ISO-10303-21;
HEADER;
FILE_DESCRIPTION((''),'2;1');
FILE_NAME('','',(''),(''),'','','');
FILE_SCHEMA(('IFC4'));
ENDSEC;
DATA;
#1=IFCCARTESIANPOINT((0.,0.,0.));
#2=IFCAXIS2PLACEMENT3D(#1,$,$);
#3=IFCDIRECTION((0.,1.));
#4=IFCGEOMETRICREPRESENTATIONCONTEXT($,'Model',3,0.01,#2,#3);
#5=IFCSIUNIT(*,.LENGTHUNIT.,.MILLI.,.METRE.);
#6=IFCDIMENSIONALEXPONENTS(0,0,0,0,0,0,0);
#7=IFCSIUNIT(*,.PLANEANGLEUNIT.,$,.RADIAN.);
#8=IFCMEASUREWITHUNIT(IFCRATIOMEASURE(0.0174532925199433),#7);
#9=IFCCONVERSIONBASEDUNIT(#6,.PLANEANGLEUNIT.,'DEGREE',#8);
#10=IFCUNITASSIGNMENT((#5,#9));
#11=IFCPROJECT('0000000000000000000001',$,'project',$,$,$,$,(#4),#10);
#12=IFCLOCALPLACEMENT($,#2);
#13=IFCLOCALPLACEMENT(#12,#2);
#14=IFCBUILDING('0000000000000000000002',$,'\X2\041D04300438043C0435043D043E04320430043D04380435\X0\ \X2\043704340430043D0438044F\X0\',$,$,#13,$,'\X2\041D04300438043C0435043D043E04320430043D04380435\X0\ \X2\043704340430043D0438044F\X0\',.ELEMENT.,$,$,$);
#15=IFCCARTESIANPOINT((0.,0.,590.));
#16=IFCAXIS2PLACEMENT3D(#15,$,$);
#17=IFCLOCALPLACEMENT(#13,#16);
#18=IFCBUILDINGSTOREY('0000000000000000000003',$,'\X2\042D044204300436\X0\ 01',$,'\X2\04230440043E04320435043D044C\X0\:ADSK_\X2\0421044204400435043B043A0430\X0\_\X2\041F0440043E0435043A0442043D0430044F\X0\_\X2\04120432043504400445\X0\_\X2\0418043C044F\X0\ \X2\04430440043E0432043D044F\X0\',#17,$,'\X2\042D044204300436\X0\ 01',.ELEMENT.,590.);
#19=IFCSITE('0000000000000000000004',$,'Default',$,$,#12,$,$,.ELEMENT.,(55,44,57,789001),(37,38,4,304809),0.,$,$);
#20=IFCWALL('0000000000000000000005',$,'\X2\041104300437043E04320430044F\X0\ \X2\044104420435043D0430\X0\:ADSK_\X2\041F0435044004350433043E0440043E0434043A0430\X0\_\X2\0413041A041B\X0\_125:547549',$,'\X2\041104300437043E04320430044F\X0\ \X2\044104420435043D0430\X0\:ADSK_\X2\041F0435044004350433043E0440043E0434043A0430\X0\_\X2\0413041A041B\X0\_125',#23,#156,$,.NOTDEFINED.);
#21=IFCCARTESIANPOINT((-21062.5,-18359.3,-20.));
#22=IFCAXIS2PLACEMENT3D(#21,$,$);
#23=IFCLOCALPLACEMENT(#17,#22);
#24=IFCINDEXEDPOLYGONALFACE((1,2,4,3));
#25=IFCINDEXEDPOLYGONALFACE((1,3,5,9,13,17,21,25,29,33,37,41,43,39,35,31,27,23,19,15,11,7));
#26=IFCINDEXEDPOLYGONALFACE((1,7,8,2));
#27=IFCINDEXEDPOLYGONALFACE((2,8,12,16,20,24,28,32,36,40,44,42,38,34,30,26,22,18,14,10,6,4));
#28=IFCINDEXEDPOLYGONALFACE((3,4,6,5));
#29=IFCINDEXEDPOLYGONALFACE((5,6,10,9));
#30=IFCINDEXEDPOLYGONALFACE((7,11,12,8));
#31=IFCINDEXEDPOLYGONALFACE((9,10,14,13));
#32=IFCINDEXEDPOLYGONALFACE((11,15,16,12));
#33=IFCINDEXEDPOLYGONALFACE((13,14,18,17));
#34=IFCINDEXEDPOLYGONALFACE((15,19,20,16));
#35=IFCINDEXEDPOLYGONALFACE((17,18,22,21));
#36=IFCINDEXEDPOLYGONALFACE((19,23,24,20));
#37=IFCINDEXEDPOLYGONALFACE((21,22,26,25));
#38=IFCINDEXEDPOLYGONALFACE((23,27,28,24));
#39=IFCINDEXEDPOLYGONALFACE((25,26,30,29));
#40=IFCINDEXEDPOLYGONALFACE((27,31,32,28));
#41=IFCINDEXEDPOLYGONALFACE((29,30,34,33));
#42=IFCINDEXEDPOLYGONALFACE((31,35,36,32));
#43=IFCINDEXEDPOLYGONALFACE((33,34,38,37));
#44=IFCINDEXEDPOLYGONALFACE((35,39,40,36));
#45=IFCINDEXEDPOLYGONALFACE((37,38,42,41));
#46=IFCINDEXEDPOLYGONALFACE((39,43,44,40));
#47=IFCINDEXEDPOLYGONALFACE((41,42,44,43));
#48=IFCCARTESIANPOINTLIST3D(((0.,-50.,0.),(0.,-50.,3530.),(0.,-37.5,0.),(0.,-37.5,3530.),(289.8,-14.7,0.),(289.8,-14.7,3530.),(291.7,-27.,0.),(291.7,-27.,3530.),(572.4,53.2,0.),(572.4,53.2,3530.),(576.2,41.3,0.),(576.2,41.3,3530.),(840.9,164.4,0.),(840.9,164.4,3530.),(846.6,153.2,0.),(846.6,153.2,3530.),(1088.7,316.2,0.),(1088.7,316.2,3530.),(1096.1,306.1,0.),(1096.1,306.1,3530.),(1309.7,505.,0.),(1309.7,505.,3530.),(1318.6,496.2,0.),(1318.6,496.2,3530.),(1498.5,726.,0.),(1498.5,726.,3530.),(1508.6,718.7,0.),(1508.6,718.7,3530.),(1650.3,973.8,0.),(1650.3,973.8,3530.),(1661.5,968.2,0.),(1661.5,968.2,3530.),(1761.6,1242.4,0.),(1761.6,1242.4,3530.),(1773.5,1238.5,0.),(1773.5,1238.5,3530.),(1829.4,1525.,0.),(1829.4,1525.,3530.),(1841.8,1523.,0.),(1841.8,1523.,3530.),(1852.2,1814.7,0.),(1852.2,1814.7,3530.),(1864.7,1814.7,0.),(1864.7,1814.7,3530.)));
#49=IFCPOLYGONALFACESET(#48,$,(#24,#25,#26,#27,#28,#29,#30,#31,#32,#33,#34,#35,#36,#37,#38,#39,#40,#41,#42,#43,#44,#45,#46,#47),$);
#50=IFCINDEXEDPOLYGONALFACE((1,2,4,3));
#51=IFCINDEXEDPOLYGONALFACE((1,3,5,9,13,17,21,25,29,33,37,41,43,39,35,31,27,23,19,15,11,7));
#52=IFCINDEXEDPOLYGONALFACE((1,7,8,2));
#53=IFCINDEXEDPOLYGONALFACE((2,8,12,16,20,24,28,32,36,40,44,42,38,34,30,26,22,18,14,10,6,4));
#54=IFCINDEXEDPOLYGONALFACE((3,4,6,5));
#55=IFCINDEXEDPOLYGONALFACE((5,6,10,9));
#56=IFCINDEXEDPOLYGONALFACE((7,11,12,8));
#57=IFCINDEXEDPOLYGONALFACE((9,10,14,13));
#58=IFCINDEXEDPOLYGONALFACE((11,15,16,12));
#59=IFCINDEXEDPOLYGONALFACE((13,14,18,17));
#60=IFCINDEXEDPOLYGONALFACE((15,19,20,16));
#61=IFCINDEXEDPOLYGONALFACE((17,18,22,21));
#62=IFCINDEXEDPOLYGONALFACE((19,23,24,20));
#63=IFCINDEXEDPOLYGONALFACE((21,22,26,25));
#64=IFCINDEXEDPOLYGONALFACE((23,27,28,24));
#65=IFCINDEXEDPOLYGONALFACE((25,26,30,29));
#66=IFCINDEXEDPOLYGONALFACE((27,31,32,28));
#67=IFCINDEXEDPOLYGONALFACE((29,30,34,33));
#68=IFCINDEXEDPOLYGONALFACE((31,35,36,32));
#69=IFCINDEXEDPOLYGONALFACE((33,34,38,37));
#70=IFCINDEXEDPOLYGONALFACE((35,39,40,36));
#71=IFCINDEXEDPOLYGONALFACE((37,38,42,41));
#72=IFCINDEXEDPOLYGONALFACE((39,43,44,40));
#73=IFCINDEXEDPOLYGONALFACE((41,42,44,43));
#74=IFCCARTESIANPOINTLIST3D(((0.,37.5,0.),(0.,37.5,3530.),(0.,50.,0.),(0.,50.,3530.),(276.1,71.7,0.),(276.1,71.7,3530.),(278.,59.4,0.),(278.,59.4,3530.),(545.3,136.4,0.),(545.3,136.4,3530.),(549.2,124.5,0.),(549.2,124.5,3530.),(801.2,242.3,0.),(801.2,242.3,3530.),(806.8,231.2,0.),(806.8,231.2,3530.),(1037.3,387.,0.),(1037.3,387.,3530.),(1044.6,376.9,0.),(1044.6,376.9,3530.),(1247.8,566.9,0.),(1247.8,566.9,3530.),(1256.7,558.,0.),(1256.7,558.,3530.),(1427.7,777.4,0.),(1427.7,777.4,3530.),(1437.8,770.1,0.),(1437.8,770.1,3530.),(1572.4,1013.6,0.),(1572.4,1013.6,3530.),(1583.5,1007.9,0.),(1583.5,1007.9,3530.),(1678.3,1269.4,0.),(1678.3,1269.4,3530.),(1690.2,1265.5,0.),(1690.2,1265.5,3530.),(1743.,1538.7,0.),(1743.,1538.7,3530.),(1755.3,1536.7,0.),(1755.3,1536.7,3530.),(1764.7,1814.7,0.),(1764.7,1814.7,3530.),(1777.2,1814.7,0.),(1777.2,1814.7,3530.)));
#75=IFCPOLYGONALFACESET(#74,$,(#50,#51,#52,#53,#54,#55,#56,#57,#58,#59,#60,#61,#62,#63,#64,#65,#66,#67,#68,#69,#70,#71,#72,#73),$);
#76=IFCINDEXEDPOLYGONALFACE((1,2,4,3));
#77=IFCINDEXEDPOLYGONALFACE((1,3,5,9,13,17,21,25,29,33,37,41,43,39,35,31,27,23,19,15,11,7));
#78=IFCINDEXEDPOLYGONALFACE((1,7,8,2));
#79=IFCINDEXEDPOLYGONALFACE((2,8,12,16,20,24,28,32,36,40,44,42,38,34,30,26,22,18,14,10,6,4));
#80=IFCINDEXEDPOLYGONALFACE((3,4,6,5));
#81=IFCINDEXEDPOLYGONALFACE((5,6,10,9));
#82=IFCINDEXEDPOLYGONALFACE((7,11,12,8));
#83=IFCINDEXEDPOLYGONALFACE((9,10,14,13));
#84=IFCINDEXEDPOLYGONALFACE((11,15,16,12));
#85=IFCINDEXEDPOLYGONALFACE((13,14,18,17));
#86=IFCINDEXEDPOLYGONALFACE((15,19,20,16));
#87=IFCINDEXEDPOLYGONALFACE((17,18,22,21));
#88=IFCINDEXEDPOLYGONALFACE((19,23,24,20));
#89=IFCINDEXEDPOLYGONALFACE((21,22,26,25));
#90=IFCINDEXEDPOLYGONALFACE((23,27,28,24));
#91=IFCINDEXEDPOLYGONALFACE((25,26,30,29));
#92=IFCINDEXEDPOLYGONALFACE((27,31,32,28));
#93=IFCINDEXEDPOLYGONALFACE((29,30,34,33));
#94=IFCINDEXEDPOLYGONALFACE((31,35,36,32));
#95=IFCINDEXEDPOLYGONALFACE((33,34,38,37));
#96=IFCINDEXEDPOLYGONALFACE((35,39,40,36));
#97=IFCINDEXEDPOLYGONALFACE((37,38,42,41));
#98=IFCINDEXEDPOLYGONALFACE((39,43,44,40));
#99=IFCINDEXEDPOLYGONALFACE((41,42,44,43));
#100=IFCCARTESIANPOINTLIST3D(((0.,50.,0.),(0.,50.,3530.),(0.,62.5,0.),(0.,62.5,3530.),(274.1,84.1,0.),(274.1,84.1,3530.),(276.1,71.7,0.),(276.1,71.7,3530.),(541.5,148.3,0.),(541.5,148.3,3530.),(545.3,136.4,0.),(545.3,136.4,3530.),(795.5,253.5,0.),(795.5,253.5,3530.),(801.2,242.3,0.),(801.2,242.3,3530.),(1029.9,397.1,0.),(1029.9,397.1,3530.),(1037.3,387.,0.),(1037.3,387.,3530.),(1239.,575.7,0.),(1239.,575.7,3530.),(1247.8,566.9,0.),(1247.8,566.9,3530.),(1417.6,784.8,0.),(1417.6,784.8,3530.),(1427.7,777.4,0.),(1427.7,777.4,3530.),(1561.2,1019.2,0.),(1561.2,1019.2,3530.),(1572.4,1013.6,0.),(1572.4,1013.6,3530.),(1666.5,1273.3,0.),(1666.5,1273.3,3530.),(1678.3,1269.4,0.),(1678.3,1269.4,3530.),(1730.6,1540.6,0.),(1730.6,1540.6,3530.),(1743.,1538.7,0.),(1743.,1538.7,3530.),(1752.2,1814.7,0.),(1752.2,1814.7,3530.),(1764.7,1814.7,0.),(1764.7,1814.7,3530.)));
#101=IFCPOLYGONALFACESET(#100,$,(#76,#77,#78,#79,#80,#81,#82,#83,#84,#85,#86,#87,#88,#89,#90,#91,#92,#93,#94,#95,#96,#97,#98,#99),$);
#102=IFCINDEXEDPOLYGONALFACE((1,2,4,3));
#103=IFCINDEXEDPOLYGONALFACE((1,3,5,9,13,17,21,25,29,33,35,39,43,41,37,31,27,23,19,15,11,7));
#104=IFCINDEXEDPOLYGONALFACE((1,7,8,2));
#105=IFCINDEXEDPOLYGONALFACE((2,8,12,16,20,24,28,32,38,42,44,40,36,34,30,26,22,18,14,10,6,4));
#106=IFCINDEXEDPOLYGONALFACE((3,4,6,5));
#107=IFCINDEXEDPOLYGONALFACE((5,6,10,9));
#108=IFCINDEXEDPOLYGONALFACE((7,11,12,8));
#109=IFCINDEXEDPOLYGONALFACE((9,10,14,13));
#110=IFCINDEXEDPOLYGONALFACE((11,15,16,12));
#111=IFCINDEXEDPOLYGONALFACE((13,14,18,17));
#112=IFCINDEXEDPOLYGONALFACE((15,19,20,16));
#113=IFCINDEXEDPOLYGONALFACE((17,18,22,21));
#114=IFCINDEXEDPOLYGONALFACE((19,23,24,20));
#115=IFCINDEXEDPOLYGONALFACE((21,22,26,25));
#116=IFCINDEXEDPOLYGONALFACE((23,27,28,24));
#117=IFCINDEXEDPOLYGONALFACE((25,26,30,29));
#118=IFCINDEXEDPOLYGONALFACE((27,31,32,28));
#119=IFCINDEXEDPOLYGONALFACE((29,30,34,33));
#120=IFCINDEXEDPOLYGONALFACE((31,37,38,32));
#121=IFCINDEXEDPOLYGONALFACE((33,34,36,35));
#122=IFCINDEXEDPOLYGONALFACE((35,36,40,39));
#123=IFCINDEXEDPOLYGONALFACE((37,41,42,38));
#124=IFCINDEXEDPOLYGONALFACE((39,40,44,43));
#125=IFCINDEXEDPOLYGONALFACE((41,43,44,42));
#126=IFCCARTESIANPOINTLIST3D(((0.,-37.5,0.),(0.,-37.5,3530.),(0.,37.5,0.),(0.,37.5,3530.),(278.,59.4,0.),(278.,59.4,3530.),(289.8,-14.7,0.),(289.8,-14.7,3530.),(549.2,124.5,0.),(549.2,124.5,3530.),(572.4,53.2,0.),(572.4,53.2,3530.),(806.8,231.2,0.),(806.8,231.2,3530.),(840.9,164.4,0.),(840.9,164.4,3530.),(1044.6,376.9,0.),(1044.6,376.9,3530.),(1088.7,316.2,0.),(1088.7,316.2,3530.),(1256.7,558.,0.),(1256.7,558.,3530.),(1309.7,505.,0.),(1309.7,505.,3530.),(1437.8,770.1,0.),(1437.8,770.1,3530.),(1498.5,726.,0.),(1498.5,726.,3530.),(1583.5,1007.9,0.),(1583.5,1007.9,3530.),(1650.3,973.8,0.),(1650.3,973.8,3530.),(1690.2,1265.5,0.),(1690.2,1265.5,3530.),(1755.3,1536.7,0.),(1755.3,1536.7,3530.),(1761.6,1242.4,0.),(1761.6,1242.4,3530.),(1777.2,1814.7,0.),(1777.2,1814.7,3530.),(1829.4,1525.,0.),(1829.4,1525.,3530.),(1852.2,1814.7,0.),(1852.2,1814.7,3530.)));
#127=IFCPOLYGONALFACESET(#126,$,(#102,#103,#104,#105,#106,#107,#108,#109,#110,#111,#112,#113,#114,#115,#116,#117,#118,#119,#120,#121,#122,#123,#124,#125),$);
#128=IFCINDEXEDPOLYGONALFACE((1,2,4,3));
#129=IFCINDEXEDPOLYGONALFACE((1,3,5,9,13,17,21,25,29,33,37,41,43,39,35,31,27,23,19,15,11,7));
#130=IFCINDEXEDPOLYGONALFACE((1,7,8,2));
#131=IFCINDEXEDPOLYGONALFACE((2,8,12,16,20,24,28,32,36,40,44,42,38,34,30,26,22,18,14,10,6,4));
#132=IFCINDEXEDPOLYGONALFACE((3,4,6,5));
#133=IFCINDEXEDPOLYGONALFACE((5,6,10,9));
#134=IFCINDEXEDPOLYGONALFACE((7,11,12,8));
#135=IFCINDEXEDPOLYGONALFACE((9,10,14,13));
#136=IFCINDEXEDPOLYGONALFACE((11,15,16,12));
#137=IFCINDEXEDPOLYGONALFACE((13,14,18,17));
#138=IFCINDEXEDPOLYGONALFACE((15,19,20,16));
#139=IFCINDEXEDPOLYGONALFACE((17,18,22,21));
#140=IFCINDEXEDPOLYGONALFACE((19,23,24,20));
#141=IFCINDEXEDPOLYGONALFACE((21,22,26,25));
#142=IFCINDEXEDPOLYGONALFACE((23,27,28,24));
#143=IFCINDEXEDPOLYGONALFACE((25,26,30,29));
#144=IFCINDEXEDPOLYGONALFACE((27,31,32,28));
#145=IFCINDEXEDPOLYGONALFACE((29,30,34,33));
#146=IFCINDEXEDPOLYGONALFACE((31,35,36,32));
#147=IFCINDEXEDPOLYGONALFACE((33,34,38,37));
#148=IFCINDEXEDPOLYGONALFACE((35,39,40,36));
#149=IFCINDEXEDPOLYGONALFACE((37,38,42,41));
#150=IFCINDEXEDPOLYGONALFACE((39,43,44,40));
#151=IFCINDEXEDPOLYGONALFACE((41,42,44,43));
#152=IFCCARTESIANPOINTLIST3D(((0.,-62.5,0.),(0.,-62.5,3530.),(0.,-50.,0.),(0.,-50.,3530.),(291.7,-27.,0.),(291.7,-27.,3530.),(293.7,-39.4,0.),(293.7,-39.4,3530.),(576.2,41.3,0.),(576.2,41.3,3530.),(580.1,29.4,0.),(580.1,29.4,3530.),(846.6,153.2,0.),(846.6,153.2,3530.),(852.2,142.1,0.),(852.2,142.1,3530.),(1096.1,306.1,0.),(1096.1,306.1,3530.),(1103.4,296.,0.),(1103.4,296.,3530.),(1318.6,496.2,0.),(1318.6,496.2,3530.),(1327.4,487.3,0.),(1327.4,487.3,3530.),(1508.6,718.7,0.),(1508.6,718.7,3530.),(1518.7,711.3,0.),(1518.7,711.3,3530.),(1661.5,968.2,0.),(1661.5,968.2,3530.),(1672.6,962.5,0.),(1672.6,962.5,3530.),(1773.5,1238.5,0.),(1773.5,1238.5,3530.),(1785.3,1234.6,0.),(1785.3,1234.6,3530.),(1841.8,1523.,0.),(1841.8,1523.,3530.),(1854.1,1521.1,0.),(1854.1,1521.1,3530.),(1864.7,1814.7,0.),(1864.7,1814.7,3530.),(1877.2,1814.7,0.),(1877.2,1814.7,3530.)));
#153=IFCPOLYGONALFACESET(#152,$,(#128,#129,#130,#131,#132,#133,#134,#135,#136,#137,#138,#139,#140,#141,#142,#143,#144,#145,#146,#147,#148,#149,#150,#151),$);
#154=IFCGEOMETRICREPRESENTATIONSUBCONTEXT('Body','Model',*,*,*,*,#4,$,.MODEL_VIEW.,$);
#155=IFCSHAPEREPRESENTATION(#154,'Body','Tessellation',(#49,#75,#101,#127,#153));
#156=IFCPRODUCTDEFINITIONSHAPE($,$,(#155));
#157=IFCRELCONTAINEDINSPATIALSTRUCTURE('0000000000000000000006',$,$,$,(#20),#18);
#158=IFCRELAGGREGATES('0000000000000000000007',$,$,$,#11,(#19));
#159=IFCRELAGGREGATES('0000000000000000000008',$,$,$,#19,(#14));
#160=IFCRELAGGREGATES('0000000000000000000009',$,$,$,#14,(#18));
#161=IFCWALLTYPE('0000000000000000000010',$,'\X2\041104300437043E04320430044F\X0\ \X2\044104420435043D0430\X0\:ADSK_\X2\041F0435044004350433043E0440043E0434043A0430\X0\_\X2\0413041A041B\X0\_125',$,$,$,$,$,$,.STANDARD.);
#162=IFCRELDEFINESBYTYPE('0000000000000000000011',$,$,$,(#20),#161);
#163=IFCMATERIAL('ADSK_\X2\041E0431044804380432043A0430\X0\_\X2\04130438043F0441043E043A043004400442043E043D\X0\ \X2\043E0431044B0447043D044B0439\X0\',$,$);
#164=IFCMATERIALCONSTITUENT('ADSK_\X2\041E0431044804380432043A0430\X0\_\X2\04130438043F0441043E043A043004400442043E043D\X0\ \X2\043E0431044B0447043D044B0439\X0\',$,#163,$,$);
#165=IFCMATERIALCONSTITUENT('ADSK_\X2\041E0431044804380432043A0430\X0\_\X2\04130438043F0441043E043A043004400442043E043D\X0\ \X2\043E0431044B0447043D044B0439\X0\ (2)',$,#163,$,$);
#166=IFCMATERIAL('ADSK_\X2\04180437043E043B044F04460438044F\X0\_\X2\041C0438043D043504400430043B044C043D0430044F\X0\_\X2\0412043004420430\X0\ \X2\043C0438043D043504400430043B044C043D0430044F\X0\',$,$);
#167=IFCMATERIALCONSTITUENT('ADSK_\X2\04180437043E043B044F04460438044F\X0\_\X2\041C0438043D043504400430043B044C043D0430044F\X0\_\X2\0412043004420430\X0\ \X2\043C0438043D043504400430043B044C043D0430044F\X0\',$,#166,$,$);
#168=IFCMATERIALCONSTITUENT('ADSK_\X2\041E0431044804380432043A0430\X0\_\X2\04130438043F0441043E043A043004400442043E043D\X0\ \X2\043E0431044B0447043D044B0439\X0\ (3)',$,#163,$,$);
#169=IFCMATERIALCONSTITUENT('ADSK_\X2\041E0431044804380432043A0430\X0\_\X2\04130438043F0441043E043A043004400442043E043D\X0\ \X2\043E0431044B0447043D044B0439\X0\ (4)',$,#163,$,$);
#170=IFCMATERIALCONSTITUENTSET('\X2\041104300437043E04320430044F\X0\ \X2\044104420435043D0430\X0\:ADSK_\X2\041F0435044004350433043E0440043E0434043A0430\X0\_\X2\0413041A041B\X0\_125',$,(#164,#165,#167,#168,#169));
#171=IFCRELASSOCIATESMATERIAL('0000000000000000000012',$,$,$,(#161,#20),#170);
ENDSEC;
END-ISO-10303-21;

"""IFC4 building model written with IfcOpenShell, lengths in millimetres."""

from ifc_helpers import new_model, entity, si_unit, converted_unit, direction, frame, origin, place, context, subcontext, project, spatial, indexed_curve, outline, extrude, material, constituent, constituent_set, type_object, element, save


model = new_model("IFC4")

# Units and contexts
model_context = context("Model", 3, precision=0.01, world=origin(), true_north=direction((0.0, 1.0)))
body_context = subcontext(model_context, "Body", "Model", "MODEL_VIEW")
ifc_project = project(units=[si_unit("LENGTHUNIT", "METRE", prefix="MILLI"), converted_unit("PLANEANGLEUNIT", "DEGREE", entity("IfcRatioMeasure", 0.0174532925199433), si_unit("PLANEANGLEUNIT", "RADIAN"), dimensions=[0, 0, 0, 0, 0, 0, 0])], contexts=[model_context])

# Site, building, storey
site_placement = place(None, origin())
site = spatial("IfcSite", under=ifc_project, at=site_placement, Name="Default", CompositionType="ELEMENT", RefLatitude=(55, 44, 57, 789001), RefLongitude=(37, 38, 4, 304809), RefElevation=0.0)
building_placement = place(site_placement, origin())
building = spatial("IfcBuilding", under=site, at=building_placement, Name="Наименование здания", LongName="Наименование здания", CompositionType="ELEMENT")
storey_placement = place(building_placement, frame((0.0, 0.0, 590.0)))
storey = spatial("IfcBuildingStorey", under=building, at=storey_placement, Name="Этаж 01", ObjectType="Уровень:ADSK_Стрелка_Проектная_Вверх_Имя уровня", LongName="Этаж 01", CompositionType="ELEMENT", Elevation=590.0)

# Shared definitions
ifc_material_1 = material(Name="ADSK_Обшивка_Гипсокартон обычный")
ifc_constituent_1 = constituent(ifc_material_1, Name="ADSK_Обшивка_Гипсокартон обычный")
ifc_constituent_2 = constituent(ifc_material_1, Name="ADSK_Обшивка_Гипсокартон обычный (2)")
ifc_material_2 = material(Name="ADSK_Изоляция_Минеральная_Вата минеральная")
ifc_constituent_3 = constituent(ifc_material_2, Name="ADSK_Изоляция_Минеральная_Вата минеральная")
ifc_constituent_4 = constituent(ifc_material_1, Name="ADSK_Обшивка_Гипсокартон обычный (3)")
ifc_constituent_5 = constituent(ifc_material_1, Name="ADSK_Обшивка_Гипсокартон обычный (4)")
ifc_constituent_set_1 = constituent_set(constituents=[ifc_constituent_1, ifc_constituent_2, ifc_constituent_3, ifc_constituent_4, ifc_constituent_5], Name="Базовая стена:ADSK_Перегородка_ГКЛ_125")
wall_type_1 = type_object("IfcWallType", Name="Базовая стена:ADSK_Перегородка_ГКЛ_125", PredefinedType="STANDARD", material=ifc_constituent_set_1)

# Wall
wall_1_placement = place(storey_placement, frame((-21062.5, -18359.3, -20.0)))
element("IfcWall", 1, at=wall_1_placement, inside=storey, type_object=wall_type_1, material=ifc_constituent_set_1, Name="Базовая стена:ADSK_Перегородка_ГКЛ_125:547549", ObjectType="Базовая стена:ADSK_Перегородка_ГКЛ_125", PredefinedType="NOTDEFINED", context=body_context, shape_type="SweptSolid", body=[
    extrude(outline(indexed_curve([(-938.8, -913.3), (-938.9, -925.8), (-647.0, -905.8), (-361.8, -840.5), (-90.3, -731.3), (160.8, -581.1), (385.2, -393.4), (577.6, -172.8), (733.1, 75.0), (847.9, 344.2), (919.1, 628.0), (945.1, 919.4), (932.6, 919.6), (906.8, 630.1), (836.0, 348.2), (722.0, 80.8), (567.6, -165.4), (376.5, -384.4), (153.5, -570.9), (-95.9, -720.1), (-365.5, -828.6), (-648.8, -893.5), (-938.8, -913.3)], self_intersect=False)), frame((929.2, 885.5, 0.0), z_axis=(0.0, 0.0, -1.0), x_axis=(-0.010416, -0.999946, 0.0)), (0.0, 0.0, -1.0), 3530.0),
    extrude(outline(indexed_curve([(-894.6, -870.0), (-894.7, -882.5), (-616.5, -863.5), (-344.7, -801.2), (-85.9, -697.2), (153.4, -553.9), (367.3, -375.0), (550.6, -164.9), (698.8, 71.4), (808.2, 327.9), (876.1, 598.4), (900.9, 876.1), (888.4, 876.3), (863.8, 600.5), (796.4, 331.9), (687.7, 77.2), (540.6, -157.4), (358.6, -366.1), (146.1, -543.8), (-91.5, -686.0), (-348.4, -789.3), (-618.3, -851.1), (-894.6, -870.0)], self_intersect=False)), frame((885.5, 929.2, 0.0), z_axis=(0.0, 0.0, -1.0), x_axis=(-0.010416, -0.999946, 0.0)), (0.0, 0.0, -1.0), 3530.0),
    extrude(outline(indexed_curve([(873.0, 879.2), (851.4, 605.1), (787.2, 337.8), (682.0, 83.7), (538.3, -150.7), (359.8, -359.8), (150.7, -538.3), (-83.7, -682.0), (-337.8, -787.2), (-605.1, -851.4), (-879.2, -873.0), (-879.2, -885.5), (-603.2, -863.8), (-333.9, -799.1), (-78.1, -693.1), (158.0, -548.5), (368.6, -368.6), (548.5, -158.0), (693.1, 78.1), (799.1, 333.9), (863.8, 603.2), (885.5, 879.2), (873.0, 879.2)], self_intersect=False)), frame((879.2, 935.5, 0.0), z_axis=(0.0, 0.0, -1.0), x_axis=(0.0, -1.0, 0.0)), (0.0, 0.0, -1.0), 3530.0),
    extrude(outline(indexed_curve([(-916.4, -860.4), (-917.2, -935.4), (-627.2, -915.6), (-343.9, -850.7), (-74.2, -742.2), (175.2, -593.0), (398.1, -406.5), (589.2, -187.5), (743.6, 58.7), (857.6, 326.1), (928.4, 608.0), (954.3, 897.5), (879.3, 898.3), (854.5, 620.5), (786.6, 350.0), (677.2, 93.5), (529.0, -142.8), (345.7, -352.9), (131.7, -531.8), (-107.6, -675.1), (-366.3, -779.1), (-638.1, -841.4), (-916.4, -860.4)], self_intersect=False)), frame((907.4, 907.4, 0.0), z_axis=(0.0, 0.0, -1.0), x_axis=(-0.010416, -0.999946, 0.0)), (0.0, 0.0, -1.0), 3530.0),
    extrude(outline(indexed_curve([(-941.7, -935.5), (-929.2, -935.5), (-906.3, -643.8), (-838.0, -359.3), (-726.0, -88.9), (-573.1, 160.6), (-383.1, 383.1), (-160.6, 573.1), (88.9, 726.0), (359.3, 838.0), (643.8, 906.3), (935.5, 929.2), (935.5, 941.7), (641.8, 918.6), (355.4, 849.9), (83.2, 737.1), (-167.9, 583.2), (-391.9, 391.9), (-583.2, 167.9), (-737.1, -83.2), (-849.9, -355.4), (-918.6, -641.8), (-941.7, -935.5)], self_intersect=False)), frame((935.5, 879.2, 0.0), z_axis=(0.0, 0.0, 1.0), x_axis=(-1.0, 0.0, 0.0)), (0.0, 0.0, 1.0), 3530.0),
])

save(model, "model.ifc")
